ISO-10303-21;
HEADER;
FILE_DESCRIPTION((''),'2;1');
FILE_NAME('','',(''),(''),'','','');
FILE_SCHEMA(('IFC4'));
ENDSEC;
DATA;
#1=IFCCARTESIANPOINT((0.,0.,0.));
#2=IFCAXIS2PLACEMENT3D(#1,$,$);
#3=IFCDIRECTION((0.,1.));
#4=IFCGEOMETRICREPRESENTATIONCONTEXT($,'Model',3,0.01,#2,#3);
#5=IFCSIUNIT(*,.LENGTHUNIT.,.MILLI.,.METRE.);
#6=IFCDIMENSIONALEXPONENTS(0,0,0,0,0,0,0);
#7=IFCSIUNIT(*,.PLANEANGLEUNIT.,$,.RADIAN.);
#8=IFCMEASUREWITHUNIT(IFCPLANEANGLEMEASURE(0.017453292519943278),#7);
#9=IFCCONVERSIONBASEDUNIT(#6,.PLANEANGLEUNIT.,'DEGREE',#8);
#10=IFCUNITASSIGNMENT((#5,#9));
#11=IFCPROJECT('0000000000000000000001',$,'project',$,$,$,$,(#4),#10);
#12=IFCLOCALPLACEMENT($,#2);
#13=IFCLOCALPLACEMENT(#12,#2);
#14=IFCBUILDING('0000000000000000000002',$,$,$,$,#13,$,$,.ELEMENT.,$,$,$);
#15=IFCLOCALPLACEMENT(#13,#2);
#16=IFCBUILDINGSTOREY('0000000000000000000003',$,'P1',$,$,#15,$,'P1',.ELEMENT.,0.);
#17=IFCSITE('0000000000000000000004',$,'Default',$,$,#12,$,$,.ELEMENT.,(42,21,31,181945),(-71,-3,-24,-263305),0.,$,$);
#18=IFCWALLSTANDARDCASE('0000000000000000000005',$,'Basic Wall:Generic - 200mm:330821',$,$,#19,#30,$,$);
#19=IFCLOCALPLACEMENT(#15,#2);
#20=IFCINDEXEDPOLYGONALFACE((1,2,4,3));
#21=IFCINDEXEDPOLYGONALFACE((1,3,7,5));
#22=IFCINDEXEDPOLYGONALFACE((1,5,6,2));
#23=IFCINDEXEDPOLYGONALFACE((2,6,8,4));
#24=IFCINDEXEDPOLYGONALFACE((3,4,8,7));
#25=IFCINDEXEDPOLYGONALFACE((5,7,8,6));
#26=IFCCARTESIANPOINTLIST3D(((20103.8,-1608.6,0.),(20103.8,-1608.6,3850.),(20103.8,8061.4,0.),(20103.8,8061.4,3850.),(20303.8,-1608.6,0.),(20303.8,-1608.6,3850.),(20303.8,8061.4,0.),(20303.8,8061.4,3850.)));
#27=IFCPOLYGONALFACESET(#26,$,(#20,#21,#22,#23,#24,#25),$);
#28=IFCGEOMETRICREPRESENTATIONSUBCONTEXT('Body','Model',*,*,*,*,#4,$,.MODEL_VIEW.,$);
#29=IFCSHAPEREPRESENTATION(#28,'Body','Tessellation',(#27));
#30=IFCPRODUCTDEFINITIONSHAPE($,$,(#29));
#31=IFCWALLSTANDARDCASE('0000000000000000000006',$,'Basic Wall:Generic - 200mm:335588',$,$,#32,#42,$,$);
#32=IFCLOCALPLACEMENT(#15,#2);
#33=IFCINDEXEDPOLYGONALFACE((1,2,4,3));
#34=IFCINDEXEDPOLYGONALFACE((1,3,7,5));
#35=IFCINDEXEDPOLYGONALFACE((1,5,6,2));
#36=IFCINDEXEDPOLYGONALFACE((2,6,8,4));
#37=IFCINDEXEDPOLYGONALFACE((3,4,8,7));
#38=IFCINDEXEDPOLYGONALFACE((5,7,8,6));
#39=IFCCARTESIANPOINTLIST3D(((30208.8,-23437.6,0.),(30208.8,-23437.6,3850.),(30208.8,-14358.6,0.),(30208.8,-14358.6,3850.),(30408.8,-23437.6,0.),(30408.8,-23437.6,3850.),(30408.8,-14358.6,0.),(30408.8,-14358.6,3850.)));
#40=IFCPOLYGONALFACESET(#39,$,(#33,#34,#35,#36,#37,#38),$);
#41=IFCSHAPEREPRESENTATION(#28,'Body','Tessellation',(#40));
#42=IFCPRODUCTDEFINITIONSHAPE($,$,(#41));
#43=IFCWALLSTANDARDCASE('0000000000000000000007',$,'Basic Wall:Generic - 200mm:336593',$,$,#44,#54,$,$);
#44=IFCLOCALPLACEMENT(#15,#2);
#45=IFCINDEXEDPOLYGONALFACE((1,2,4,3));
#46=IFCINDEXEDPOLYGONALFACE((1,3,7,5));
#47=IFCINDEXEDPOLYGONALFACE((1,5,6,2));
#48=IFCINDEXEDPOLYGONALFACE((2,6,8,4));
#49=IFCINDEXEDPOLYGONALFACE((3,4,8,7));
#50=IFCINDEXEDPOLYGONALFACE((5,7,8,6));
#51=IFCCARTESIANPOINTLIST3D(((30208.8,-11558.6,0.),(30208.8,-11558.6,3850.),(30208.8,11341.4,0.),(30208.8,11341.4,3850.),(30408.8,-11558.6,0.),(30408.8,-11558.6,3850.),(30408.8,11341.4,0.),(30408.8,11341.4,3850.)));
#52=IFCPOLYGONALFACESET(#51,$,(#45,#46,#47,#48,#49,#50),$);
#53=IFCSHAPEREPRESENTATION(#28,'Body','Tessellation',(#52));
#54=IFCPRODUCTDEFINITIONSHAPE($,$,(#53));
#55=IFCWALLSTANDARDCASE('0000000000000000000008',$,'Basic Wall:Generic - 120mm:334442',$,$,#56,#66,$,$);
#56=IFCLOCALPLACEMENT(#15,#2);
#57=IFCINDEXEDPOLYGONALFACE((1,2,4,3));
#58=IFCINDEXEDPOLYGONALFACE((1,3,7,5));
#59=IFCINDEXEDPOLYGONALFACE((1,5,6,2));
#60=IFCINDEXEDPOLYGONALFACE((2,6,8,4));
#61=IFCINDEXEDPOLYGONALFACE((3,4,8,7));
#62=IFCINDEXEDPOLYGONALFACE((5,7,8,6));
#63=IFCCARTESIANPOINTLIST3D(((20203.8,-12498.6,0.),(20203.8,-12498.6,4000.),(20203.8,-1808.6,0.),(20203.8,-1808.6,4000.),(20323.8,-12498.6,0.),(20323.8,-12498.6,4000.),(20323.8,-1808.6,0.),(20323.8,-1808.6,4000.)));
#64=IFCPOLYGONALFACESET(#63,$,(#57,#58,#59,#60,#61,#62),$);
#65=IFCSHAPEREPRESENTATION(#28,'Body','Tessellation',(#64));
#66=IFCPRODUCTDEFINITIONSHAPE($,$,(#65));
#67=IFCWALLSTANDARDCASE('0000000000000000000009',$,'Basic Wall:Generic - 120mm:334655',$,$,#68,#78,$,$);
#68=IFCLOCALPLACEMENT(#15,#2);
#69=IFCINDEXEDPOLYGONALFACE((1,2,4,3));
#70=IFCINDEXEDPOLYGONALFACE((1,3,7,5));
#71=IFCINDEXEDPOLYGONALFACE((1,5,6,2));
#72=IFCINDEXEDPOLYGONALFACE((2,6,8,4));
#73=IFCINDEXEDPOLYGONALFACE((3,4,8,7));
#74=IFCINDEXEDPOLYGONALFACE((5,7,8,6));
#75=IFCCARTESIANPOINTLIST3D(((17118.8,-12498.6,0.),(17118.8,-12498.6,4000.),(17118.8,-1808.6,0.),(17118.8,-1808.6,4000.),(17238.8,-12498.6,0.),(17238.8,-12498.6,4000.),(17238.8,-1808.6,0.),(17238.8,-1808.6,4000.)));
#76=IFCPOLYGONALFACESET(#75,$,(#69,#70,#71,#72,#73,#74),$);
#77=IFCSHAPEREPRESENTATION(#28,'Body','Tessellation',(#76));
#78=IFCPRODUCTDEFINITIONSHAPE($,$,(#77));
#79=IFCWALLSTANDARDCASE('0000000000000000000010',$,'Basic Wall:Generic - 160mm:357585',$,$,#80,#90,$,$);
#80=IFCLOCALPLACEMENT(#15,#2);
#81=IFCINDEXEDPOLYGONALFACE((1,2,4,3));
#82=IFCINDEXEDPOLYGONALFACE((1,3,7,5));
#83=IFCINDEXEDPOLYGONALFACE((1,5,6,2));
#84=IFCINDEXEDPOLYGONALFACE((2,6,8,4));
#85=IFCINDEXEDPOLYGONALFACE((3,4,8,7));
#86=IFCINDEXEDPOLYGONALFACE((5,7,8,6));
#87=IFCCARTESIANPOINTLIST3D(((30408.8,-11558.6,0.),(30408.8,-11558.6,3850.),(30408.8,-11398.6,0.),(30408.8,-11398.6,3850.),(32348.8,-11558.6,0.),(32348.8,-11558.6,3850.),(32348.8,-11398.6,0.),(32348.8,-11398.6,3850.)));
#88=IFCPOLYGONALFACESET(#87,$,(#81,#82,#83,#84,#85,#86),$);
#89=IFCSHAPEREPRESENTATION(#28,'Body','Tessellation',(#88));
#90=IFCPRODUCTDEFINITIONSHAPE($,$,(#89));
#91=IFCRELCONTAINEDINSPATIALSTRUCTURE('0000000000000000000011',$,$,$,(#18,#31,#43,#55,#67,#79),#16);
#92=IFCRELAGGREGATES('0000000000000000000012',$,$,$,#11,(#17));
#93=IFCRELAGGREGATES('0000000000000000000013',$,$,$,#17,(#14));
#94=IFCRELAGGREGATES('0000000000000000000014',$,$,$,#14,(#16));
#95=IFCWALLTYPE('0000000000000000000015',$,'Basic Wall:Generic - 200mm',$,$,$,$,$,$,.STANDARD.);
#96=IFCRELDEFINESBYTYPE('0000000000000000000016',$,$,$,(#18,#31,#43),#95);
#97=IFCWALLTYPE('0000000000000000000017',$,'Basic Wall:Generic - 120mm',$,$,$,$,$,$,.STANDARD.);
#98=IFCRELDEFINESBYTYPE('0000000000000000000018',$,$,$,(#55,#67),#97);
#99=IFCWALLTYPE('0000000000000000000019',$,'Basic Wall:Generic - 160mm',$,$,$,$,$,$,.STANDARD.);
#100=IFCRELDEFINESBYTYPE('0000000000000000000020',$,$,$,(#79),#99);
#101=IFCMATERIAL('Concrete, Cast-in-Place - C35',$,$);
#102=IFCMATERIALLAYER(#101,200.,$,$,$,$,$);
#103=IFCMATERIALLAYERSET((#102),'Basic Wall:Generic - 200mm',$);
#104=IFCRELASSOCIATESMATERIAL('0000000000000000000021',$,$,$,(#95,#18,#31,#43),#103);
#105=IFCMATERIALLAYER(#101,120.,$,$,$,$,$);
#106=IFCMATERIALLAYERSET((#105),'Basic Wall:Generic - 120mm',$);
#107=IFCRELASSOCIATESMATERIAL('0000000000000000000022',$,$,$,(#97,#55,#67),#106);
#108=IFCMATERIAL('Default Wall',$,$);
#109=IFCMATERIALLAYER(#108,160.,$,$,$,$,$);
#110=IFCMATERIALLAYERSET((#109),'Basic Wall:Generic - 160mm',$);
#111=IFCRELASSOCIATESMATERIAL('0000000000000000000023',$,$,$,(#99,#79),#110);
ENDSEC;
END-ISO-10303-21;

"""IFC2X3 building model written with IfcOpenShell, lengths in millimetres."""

from ifc_helpers import new_model, entity, si_unit, converted_unit, direction, frame, frame_2d, origin, place, context, subcontext, project, spatial, rectangle, extrude, material, layer, layer_set, layer_usage, type_object, element, save


model = new_model("IFC2X3")

# Units and contexts
model_context = context("Model", 3, precision=0.01, world=origin(), true_north=direction((0.0, 1.0)))
body_context = subcontext(model_context, "Body", "Model", "MODEL_VIEW")
ifc_project = project(units=[si_unit("LENGTHUNIT", "METRE", prefix="MILLI"), converted_unit("PLANEANGLEUNIT", "DEGREE", entity("IfcPlaneAngleMeasure", 0.017453292519943278), si_unit("PLANEANGLEUNIT", "RADIAN"), dimensions=[0, 0, 0, 0, 0, 0, 0])], contexts=[model_context])

# Site, building, storey
site_placement = place(None, origin())
site = spatial("IfcSite", under=ifc_project, at=site_placement, Name="Default", CompositionType="ELEMENT", RefLatitude=(42, 21, 31, 181945), RefLongitude=(-71, -3, -24, -263305), RefElevation=0.0)
building_placement = place(site_placement, origin())
building = spatial("IfcBuilding", under=site, at=building_placement, CompositionType="ELEMENT")
storey_placement = place(building_placement, origin())
storey = spatial("IfcBuildingStorey", under=building, at=storey_placement, Name="P1", LongName="P1", CompositionType="ELEMENT", Elevation=0.0)

# Shared definitions
ifc_material_1 = material(Name="Concrete, Cast-in-Place - C35")

# Walls
ifc_layer_1 = layer(ifc_material_1, 200.0)
ifc_layer_set_1 = layer_set([ifc_layer_1], Name="Basic Wall:Generic - 200mm")
ifc_layer_usage_1 = layer_usage(ifc_layer_set_1, "AXIS2", "NEGATIVE", 100.0)
wall_type_1 = type_object("IfcWallType", Name="Basic Wall:Generic - 200mm", PredefinedType="STANDARD", material=ifc_layer_set_1)
wall_1_placement = place(storey_placement, frame((20203.8, -1608.6, 0.0), z_axis=(0.0, 0.0, 1.0), x_axis=(0.0, 1.0, 0.0)))
element("IfcWallStandardCase", 1, at=wall_1_placement, inside=storey, type_object=wall_type_1, material=ifc_layer_usage_1, Name="Basic Wall:Generic - 200mm:330821", context=body_context, shape_type="SweptSolid", body=[
    extrude(rectangle(XDim=9670.0, YDim=200.0, at=frame_2d((4835.0, 0.0), x_axis=(-1.0, 0.0))), origin(), (0.0, 0.0, 1.0), 3850.0),
])
ifc_layer_usage_2 = layer_usage(ifc_layer_set_1, "AXIS2", "NEGATIVE", 100.0)
wall_2_placement = place(storey_placement, frame((30308.8, -23437.6, 0.0), z_axis=(0.0, 0.0, 1.0), x_axis=(0.0, 1.0, 0.0)))
element("IfcWallStandardCase", 2, at=wall_2_placement, inside=storey, type_object=wall_type_1, material=ifc_layer_usage_2, Name="Basic Wall:Generic - 200mm:335588", context=body_context, shape_type="SweptSolid", body=[
    extrude(rectangle(XDim=9079.0, YDim=200.0, at=frame_2d((4539.5, 0.0), x_axis=(-1.0, 0.0))), origin(), (0.0, 0.0, 1.0), 3850.0),
])
ifc_layer_usage_3 = layer_usage(ifc_layer_set_1, "AXIS2", "NEGATIVE", 100.0)
wall_3_placement = place(storey_placement, frame((30308.8, -11558.6, 0.0), z_axis=(0.0, 0.0, 1.0), x_axis=(0.0, 1.0, 0.0)))
element("IfcWallStandardCase", 3, at=wall_3_placement, inside=storey, type_object=wall_type_1, material=ifc_layer_usage_3, Name="Basic Wall:Generic - 200mm:336593", context=body_context, shape_type="SweptSolid", body=[
    extrude(rectangle(XDim=22900.0, YDim=200.0, at=frame_2d((11450.0, 0.0), x_axis=(-1.0, 0.0))), origin(), (0.0, 0.0, 1.0), 3850.0),
])
ifc_layer_2 = layer(ifc_material_1, 120.0)
ifc_layer_set_2 = layer_set([ifc_layer_2], Name="Basic Wall:Generic - 120mm")
ifc_layer_usage_4 = layer_usage(ifc_layer_set_2, "AXIS2", "NEGATIVE", 60.0)
wall_type_2 = type_object("IfcWallType", Name="Basic Wall:Generic - 120mm", PredefinedType="STANDARD", material=ifc_layer_set_2)
wall_4_placement = place(storey_placement, frame((20263.8, -1808.6, 0.0), z_axis=(0.0, 0.0, 1.0), x_axis=(0.0, -1.0, 0.0)))
element("IfcWallStandardCase", 4, at=wall_4_placement, inside=storey, type_object=wall_type_2, material=ifc_layer_usage_4, Name="Basic Wall:Generic - 120mm:334442", context=body_context, shape_type="SweptSolid", body=[
    extrude(rectangle(XDim=10690.0, YDim=120.0, at=frame_2d((5345.0, 0.0), x_axis=(-1.0, 0.0))), origin(), (0.0, 0.0, 1.0), 4000.0),
])
ifc_layer_usage_5 = layer_usage(ifc_layer_set_2, "AXIS2", "NEGATIVE", 60.0)
wall_5_placement = place(storey_placement, frame((17178.8, -1808.6, 0.0), z_axis=(0.0, 0.0, 1.0), x_axis=(0.0, -1.0, 0.0)))
element("IfcWallStandardCase", 5, at=wall_5_placement, inside=storey, type_object=wall_type_2, material=ifc_layer_usage_5, Name="Basic Wall:Generic - 120mm:334655", context=body_context, shape_type="SweptSolid", body=[
    extrude(rectangle(XDim=10690.0, YDim=120.0, at=frame_2d((5345.0, 0.0), x_axis=(-1.0, 0.0))), origin(), (0.0, 0.0, 1.0), 4000.0),
])
ifc_material_2 = material(Name="Default Wall")
ifc_layer_3 = layer(ifc_material_2, 160.0)
ifc_layer_set_3 = layer_set([ifc_layer_3], Name="Basic Wall:Generic - 160mm")
ifc_layer_usage_6 = layer_usage(ifc_layer_set_3, "AXIS2", "NEGATIVE", 80.0)
wall_type_3 = type_object("IfcWallType", Name="Basic Wall:Generic - 160mm", PredefinedType="STANDARD", material=ifc_layer_set_3)
wall_6_placement = place(storey_placement, frame((30408.8, -11478.6, 0.0)))
element("IfcWallStandardCase", 6, at=wall_6_placement, inside=storey, type_object=wall_type_3, material=ifc_layer_usage_6, Name="Basic Wall:Generic - 160mm:357585", context=body_context, shape_type="SweptSolid", body=[
    extrude(rectangle(XDim=1940.0, YDim=160.0, at=frame_2d((970.0, 0.0), x_axis=(-1.0, 0.0))), origin(), (0.0, 0.0, 1.0), 3850.0),
])

save(model, "model.ifc")
